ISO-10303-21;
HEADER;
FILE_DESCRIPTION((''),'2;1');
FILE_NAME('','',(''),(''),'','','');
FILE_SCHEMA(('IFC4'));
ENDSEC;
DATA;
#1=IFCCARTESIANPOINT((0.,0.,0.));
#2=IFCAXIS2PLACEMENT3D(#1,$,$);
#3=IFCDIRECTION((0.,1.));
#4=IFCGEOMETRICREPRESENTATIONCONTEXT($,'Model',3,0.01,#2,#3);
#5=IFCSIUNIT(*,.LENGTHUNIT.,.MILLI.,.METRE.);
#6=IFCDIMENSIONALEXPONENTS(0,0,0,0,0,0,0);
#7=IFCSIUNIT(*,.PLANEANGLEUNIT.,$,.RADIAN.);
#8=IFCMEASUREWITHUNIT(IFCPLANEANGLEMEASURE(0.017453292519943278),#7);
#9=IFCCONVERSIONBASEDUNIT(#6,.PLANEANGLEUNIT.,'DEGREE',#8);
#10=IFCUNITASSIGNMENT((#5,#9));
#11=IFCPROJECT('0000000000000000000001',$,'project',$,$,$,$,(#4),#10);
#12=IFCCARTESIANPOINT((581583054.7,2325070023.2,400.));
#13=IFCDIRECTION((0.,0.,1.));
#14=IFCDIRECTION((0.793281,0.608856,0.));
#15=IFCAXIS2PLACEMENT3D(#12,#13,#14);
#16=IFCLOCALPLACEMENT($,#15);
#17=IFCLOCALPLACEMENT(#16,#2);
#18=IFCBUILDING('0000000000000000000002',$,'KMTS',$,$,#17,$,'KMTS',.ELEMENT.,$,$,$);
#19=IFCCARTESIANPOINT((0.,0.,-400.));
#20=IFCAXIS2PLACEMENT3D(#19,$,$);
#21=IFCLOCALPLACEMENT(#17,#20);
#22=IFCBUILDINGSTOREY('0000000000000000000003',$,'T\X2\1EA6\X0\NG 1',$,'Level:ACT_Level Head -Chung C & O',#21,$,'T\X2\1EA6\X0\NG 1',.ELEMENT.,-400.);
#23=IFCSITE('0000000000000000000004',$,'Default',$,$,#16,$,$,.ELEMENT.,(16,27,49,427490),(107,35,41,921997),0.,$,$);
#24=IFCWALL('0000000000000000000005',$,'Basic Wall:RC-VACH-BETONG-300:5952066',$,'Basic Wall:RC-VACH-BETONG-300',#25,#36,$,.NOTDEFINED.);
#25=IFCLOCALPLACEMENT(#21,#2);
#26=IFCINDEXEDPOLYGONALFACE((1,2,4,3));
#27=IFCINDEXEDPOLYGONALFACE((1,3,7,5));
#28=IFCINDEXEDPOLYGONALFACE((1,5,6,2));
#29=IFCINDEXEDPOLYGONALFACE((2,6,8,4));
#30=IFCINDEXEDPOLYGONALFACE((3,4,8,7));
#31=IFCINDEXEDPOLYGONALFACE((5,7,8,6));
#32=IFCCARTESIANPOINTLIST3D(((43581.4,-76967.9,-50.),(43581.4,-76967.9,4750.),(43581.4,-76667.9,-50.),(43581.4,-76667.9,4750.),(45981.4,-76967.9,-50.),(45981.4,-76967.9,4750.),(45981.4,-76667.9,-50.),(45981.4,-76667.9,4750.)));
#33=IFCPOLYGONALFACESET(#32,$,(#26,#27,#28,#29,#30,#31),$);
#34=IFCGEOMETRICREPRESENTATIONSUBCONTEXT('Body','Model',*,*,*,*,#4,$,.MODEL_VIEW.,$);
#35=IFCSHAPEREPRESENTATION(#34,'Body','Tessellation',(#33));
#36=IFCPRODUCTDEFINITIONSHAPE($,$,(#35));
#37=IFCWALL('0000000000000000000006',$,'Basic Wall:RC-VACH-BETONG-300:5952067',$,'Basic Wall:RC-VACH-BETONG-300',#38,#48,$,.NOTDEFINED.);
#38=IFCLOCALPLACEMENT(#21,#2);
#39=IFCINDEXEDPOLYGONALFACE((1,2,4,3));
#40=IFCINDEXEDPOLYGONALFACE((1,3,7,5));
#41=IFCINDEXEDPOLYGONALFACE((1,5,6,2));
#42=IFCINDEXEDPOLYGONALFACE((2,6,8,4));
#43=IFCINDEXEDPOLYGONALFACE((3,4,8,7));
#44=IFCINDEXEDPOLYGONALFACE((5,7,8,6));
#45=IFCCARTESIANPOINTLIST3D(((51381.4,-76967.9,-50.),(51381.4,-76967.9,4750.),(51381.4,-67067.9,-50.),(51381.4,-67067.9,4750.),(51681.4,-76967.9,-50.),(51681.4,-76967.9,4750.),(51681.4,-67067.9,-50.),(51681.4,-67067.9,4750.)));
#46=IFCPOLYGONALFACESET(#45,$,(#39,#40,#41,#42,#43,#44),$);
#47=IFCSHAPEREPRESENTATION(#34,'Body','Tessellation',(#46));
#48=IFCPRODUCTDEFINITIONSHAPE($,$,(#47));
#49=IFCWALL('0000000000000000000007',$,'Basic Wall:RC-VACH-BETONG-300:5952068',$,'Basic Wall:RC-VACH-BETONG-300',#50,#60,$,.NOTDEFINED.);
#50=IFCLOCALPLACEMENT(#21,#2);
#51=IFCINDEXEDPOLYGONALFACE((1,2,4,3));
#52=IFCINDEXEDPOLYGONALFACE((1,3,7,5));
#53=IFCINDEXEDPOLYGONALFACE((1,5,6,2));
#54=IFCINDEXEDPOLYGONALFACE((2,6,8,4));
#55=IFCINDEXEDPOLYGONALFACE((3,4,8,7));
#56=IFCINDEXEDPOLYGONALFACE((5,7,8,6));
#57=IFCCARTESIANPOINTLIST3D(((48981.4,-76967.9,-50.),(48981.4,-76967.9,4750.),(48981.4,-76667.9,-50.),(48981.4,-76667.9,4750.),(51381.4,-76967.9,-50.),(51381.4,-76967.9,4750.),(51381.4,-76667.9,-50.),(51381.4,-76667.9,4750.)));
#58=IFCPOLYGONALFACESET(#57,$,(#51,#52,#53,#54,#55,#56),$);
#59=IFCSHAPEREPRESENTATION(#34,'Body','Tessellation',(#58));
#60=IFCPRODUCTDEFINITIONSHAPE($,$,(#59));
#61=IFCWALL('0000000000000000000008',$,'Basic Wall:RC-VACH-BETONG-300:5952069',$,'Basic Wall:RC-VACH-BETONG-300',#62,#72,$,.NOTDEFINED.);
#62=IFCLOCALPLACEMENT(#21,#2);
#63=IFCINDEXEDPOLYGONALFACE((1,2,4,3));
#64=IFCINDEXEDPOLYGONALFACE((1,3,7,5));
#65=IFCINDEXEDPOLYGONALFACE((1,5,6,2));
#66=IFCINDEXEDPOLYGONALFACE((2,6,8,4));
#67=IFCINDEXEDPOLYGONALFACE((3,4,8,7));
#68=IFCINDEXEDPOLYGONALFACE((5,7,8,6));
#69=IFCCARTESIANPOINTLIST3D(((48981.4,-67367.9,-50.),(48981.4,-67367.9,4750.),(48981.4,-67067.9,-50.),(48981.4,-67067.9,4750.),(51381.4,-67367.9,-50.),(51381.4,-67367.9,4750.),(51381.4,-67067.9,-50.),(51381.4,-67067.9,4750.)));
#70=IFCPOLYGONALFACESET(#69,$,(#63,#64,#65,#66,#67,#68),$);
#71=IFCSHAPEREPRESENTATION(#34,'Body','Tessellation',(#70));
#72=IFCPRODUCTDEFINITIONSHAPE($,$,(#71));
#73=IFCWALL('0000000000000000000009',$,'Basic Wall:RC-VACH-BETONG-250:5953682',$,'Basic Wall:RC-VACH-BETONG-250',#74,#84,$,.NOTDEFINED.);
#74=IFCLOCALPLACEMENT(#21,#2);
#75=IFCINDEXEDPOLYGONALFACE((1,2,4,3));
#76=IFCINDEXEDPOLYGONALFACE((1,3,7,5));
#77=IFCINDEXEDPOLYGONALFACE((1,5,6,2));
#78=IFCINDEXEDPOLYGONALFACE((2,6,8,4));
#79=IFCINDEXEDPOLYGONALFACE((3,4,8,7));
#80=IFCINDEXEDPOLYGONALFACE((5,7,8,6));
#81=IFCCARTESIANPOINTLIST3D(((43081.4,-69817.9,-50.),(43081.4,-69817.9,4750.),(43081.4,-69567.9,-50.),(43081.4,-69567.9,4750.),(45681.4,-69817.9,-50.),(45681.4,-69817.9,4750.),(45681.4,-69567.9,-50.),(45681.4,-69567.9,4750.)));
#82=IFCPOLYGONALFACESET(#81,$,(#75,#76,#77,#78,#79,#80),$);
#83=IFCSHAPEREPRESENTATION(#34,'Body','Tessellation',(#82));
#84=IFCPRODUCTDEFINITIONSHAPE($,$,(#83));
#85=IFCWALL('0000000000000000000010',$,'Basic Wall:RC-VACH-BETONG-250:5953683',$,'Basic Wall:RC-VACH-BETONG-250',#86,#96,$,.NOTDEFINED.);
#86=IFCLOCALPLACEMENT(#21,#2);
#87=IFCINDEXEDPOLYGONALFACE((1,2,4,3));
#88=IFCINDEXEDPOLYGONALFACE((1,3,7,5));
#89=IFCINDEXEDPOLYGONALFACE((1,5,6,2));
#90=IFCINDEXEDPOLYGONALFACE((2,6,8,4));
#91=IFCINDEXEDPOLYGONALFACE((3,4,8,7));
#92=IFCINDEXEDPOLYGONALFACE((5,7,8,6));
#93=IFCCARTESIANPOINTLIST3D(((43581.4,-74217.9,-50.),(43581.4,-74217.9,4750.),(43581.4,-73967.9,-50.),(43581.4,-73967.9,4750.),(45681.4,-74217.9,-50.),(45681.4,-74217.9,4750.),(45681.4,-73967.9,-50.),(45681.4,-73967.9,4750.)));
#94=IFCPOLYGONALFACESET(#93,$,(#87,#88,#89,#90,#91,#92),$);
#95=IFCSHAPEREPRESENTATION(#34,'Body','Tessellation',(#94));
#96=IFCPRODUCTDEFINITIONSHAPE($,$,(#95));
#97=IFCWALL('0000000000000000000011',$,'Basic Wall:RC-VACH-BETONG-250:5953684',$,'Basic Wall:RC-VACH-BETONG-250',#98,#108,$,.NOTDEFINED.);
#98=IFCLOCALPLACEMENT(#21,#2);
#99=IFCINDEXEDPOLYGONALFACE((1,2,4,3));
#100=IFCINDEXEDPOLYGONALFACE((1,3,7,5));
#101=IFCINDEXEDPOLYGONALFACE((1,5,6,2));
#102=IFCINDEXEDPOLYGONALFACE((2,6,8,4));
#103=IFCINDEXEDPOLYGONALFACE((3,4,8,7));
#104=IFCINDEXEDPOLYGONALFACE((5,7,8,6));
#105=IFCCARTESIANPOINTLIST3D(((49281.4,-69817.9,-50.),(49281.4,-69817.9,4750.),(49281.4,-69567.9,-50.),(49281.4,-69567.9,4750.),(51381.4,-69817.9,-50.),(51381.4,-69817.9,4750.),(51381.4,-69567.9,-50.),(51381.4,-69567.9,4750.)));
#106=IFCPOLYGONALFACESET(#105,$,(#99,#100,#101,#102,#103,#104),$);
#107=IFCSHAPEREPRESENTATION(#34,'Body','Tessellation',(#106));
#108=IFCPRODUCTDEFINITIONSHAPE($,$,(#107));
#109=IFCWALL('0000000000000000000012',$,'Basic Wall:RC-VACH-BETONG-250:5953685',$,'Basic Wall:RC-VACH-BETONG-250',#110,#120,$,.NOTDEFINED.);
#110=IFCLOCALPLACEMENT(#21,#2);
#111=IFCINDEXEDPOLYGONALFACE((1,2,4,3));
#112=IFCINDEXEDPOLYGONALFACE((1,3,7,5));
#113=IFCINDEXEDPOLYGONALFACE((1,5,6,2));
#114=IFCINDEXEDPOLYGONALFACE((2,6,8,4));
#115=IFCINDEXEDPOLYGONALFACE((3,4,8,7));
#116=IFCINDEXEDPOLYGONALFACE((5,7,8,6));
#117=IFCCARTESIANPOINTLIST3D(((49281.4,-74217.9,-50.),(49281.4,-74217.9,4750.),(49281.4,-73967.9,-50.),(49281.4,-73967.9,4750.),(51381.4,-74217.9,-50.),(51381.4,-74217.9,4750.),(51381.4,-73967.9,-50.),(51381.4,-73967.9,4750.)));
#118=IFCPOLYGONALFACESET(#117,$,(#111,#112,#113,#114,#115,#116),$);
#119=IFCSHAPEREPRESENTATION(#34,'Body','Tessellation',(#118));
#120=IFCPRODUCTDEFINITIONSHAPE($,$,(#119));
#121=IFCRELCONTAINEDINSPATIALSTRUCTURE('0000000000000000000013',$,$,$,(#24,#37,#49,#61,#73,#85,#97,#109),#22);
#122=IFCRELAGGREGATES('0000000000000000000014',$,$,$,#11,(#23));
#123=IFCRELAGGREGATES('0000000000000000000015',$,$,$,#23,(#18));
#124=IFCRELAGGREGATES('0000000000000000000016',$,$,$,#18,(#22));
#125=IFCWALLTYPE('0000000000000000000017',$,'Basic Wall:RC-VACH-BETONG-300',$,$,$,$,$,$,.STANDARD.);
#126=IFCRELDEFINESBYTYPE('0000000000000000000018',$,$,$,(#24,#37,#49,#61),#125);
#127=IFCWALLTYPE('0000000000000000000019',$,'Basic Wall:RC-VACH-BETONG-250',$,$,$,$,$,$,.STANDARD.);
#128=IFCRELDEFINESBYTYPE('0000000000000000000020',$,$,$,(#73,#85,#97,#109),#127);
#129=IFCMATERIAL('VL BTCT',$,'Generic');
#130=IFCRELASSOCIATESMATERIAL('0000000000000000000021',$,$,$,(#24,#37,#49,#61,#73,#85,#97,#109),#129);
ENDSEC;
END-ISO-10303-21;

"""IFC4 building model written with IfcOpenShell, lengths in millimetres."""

from ifc_helpers import new_model, entity, si_unit, converted_unit, direction, frame, origin, place, context, subcontext, project, spatial, indexed_curve, outline, extrude, material, type_object, element, save


model = new_model("IFC4")

# Units and contexts
model_context = context("Model", 3, precision=0.01, world=origin(), true_north=direction((0.0, 1.0)))
body_context = subcontext(model_context, "Body", "Model", "MODEL_VIEW")
ifc_project = project(units=[si_unit("LENGTHUNIT", "METRE", prefix="MILLI"), converted_unit("PLANEANGLEUNIT", "DEGREE", entity("IfcPlaneAngleMeasure", 0.017453292519943278), si_unit("PLANEANGLEUNIT", "RADIAN"), dimensions=[0, 0, 0, 0, 0, 0, 0])], contexts=[model_context])

# Site, building, storey
site_placement = place(None, frame((581583054.7, 2325070023.2, 400.0), z_axis=(0.0, 0.0, 1.0), x_axis=(0.793281, 0.608856, 0.0)))
site = spatial("IfcSite", under=ifc_project, at=site_placement, Name="Default", CompositionType="ELEMENT", RefLatitude=(16, 27, 49, 427490), RefLongitude=(107, 35, 41, 921997), RefElevation=0.0)
building_placement = place(site_placement, origin())
building = spatial("IfcBuilding", under=site, at=building_placement, Name="KMTS", LongName="KMTS", CompositionType="ELEMENT")
storey_placement = place(building_placement, frame((0.0, 0.0, -400.0)))
storey = spatial("IfcBuildingStorey", under=building, at=storey_placement, Name="TẦNG 1", ObjectType="Level:ACT_Level Head -Chung C & O", LongName="TẦNG 1", CompositionType="ELEMENT", Elevation=-400.0)

# Shared definitions
ifc_material = material(Name="VL BTCT", Category="Generic")

# Walls
wall_type_1 = type_object("IfcWallType", Name="Basic Wall:RC-VACH-BETONG-300", PredefinedType="STANDARD")
wall_1_placement = place(storey_placement, frame((45981.4, -76817.9, -50.0), z_axis=(0.0, 0.0, 1.0), x_axis=(-1.0, 0.0, 0.0)))
element("IfcWall", 1, at=wall_1_placement, inside=storey, type_object=wall_type_1, material=ifc_material, Name="Basic Wall:RC-VACH-BETONG-300:5952066", ObjectType="Basic Wall:RC-VACH-BETONG-300", PredefinedType="NOTDEFINED", context=body_context, shape_type="SweptSolid", body=[
    extrude(outline(indexed_curve([(2400.0, 150.0), (0.0, 150.0), (0.0, -150.0), (2400.0, -150.0), (2400.0, 150.0)], self_intersect=False)), origin(), (0.0, 0.0, 1.0), 4800.0),
])
wall_2_placement = place(storey_placement, frame((51531.4, -67067.9, -50.0), z_axis=(0.0, 0.0, 1.0), x_axis=(0.0, -1.0, 0.0)))
element("IfcWall", 2, at=wall_2_placement, inside=storey, type_object=wall_type_1, material=ifc_material, Name="Basic Wall:RC-VACH-BETONG-300:5952067", ObjectType="Basic Wall:RC-VACH-BETONG-300", PredefinedType="NOTDEFINED", context=body_context, shape_type="SweptSolid", body=[
    extrude(outline(indexed_curve([(9900.0, 150.0), (0.0, 150.0), (0.0, -150.0), (9900.0, -150.0), (9900.0, 150.0)], self_intersect=False)), origin(), (0.0, 0.0, 1.0), 4800.0),
])
wall_3_placement = place(storey_placement, frame((51381.4, -76817.9, -50.0), z_axis=(0.0, 0.0, 1.0), x_axis=(-1.0, 0.0, 0.0)))
element("IfcWall", 3, at=wall_3_placement, inside=storey, type_object=wall_type_1, material=ifc_material, Name="Basic Wall:RC-VACH-BETONG-300:5952068", ObjectType="Basic Wall:RC-VACH-BETONG-300", PredefinedType="NOTDEFINED", context=body_context, shape_type="SweptSolid", body=[
    extrude(outline(indexed_curve([(2400.0, 150.0), (0.0, 150.0), (0.0, -150.0), (2400.0, -150.0), (2400.0, 150.0)], self_intersect=False)), origin(), (0.0, 0.0, 1.0), 4800.0),
])
wall_4_placement = place(storey_placement, frame((51381.4, -67217.9, -50.0), z_axis=(0.0, 0.0, 1.0), x_axis=(-1.0, 0.0, 0.0)))
element("IfcWall", 4, at=wall_4_placement, inside=storey, type_object=wall_type_1, material=ifc_material, Name="Basic Wall:RC-VACH-BETONG-300:5952069", ObjectType="Basic Wall:RC-VACH-BETONG-300", PredefinedType="NOTDEFINED", context=body_context, shape_type="SweptSolid", body=[
    extrude(outline(indexed_curve([(2400.0, 150.0), (0.0, 150.0), (0.0, -150.0), (2400.0, -150.0), (2400.0, 150.0)], self_intersect=False)), origin(), (0.0, 0.0, 1.0), 4800.0),
])
wall_type_2 = type_object("IfcWallType", Name="Basic Wall:RC-VACH-BETONG-250", PredefinedType="STANDARD")
wall_5_placement = place(storey_placement, frame((45681.4, -69692.9, -50.0), z_axis=(0.0, 0.0, 1.0), x_axis=(-1.0, 0.0, 0.0)))
element("IfcWall", 5, at=wall_5_placement, inside=storey, type_object=wall_type_2, material=ifc_material, Name="Basic Wall:RC-VACH-BETONG-250:5953682", ObjectType="Basic Wall:RC-VACH-BETONG-250", PredefinedType="NOTDEFINED", context=body_context, shape_type="SweptSolid", body=[
    extrude(outline(indexed_curve([(2600.0, 125.0), (0.0, 125.0), (0.0, -125.0), (2600.0, -125.0), (2600.0, 125.0)], self_intersect=False)), origin(), (0.0, 0.0, 1.0), 4800.0),
])
wall_6_placement = place(storey_placement, frame((45681.4, -74092.9, -50.0), z_axis=(0.0, 0.0, 1.0), x_axis=(-1.0, 0.0, 0.0)))
element("IfcWall", 6, at=wall_6_placement, inside=storey, type_object=wall_type_2, material=ifc_material, Name="Basic Wall:RC-VACH-BETONG-250:5953683", ObjectType="Basic Wall:RC-VACH-BETONG-250", PredefinedType="NOTDEFINED", context=body_context, shape_type="SweptSolid", body=[
    extrude(outline(indexed_curve([(2100.0, 125.0), (0.0, 125.0), (0.0, -125.0), (2100.0, -125.0), (2100.0, 125.0)], self_intersect=False)), origin(), (0.0, 0.0, 1.0), 4800.0),
])
for number, where, z_axis, x_axis, name in (
    (7, (51381.4, -69692.9, -50.0), (0.0, 0.0, 1.0), (-1.0, 0.0, 0.0), "Basic Wall:RC-VACH-BETONG-250:5953684"),
    (8, (51381.4, -74092.9, -50.0), (0.0, 0.0, 1.0), (-1.0, 0.0, 0.0), "Basic Wall:RC-VACH-BETONG-250:5953685"),
):
    element("IfcWall", number, at=place(storey_placement, frame(where, z_axis=z_axis, x_axis=x_axis)), inside=storey, type_object=wall_type_2, material=ifc_material, Name=name, ObjectType="Basic Wall:RC-VACH-BETONG-250", PredefinedType="NOTDEFINED", context=body_context, shape_type="SweptSolid", body=[
        extrude(outline(indexed_curve([(2100.0, 125.0), (0.0, 125.0), (0.0, -125.0), (2100.0, -125.0), (2100.0, 125.0)], self_intersect=False)), origin(), (0.0, 0.0, 1.0), 4800.0),
    ])

save(model, "model.ifc")
